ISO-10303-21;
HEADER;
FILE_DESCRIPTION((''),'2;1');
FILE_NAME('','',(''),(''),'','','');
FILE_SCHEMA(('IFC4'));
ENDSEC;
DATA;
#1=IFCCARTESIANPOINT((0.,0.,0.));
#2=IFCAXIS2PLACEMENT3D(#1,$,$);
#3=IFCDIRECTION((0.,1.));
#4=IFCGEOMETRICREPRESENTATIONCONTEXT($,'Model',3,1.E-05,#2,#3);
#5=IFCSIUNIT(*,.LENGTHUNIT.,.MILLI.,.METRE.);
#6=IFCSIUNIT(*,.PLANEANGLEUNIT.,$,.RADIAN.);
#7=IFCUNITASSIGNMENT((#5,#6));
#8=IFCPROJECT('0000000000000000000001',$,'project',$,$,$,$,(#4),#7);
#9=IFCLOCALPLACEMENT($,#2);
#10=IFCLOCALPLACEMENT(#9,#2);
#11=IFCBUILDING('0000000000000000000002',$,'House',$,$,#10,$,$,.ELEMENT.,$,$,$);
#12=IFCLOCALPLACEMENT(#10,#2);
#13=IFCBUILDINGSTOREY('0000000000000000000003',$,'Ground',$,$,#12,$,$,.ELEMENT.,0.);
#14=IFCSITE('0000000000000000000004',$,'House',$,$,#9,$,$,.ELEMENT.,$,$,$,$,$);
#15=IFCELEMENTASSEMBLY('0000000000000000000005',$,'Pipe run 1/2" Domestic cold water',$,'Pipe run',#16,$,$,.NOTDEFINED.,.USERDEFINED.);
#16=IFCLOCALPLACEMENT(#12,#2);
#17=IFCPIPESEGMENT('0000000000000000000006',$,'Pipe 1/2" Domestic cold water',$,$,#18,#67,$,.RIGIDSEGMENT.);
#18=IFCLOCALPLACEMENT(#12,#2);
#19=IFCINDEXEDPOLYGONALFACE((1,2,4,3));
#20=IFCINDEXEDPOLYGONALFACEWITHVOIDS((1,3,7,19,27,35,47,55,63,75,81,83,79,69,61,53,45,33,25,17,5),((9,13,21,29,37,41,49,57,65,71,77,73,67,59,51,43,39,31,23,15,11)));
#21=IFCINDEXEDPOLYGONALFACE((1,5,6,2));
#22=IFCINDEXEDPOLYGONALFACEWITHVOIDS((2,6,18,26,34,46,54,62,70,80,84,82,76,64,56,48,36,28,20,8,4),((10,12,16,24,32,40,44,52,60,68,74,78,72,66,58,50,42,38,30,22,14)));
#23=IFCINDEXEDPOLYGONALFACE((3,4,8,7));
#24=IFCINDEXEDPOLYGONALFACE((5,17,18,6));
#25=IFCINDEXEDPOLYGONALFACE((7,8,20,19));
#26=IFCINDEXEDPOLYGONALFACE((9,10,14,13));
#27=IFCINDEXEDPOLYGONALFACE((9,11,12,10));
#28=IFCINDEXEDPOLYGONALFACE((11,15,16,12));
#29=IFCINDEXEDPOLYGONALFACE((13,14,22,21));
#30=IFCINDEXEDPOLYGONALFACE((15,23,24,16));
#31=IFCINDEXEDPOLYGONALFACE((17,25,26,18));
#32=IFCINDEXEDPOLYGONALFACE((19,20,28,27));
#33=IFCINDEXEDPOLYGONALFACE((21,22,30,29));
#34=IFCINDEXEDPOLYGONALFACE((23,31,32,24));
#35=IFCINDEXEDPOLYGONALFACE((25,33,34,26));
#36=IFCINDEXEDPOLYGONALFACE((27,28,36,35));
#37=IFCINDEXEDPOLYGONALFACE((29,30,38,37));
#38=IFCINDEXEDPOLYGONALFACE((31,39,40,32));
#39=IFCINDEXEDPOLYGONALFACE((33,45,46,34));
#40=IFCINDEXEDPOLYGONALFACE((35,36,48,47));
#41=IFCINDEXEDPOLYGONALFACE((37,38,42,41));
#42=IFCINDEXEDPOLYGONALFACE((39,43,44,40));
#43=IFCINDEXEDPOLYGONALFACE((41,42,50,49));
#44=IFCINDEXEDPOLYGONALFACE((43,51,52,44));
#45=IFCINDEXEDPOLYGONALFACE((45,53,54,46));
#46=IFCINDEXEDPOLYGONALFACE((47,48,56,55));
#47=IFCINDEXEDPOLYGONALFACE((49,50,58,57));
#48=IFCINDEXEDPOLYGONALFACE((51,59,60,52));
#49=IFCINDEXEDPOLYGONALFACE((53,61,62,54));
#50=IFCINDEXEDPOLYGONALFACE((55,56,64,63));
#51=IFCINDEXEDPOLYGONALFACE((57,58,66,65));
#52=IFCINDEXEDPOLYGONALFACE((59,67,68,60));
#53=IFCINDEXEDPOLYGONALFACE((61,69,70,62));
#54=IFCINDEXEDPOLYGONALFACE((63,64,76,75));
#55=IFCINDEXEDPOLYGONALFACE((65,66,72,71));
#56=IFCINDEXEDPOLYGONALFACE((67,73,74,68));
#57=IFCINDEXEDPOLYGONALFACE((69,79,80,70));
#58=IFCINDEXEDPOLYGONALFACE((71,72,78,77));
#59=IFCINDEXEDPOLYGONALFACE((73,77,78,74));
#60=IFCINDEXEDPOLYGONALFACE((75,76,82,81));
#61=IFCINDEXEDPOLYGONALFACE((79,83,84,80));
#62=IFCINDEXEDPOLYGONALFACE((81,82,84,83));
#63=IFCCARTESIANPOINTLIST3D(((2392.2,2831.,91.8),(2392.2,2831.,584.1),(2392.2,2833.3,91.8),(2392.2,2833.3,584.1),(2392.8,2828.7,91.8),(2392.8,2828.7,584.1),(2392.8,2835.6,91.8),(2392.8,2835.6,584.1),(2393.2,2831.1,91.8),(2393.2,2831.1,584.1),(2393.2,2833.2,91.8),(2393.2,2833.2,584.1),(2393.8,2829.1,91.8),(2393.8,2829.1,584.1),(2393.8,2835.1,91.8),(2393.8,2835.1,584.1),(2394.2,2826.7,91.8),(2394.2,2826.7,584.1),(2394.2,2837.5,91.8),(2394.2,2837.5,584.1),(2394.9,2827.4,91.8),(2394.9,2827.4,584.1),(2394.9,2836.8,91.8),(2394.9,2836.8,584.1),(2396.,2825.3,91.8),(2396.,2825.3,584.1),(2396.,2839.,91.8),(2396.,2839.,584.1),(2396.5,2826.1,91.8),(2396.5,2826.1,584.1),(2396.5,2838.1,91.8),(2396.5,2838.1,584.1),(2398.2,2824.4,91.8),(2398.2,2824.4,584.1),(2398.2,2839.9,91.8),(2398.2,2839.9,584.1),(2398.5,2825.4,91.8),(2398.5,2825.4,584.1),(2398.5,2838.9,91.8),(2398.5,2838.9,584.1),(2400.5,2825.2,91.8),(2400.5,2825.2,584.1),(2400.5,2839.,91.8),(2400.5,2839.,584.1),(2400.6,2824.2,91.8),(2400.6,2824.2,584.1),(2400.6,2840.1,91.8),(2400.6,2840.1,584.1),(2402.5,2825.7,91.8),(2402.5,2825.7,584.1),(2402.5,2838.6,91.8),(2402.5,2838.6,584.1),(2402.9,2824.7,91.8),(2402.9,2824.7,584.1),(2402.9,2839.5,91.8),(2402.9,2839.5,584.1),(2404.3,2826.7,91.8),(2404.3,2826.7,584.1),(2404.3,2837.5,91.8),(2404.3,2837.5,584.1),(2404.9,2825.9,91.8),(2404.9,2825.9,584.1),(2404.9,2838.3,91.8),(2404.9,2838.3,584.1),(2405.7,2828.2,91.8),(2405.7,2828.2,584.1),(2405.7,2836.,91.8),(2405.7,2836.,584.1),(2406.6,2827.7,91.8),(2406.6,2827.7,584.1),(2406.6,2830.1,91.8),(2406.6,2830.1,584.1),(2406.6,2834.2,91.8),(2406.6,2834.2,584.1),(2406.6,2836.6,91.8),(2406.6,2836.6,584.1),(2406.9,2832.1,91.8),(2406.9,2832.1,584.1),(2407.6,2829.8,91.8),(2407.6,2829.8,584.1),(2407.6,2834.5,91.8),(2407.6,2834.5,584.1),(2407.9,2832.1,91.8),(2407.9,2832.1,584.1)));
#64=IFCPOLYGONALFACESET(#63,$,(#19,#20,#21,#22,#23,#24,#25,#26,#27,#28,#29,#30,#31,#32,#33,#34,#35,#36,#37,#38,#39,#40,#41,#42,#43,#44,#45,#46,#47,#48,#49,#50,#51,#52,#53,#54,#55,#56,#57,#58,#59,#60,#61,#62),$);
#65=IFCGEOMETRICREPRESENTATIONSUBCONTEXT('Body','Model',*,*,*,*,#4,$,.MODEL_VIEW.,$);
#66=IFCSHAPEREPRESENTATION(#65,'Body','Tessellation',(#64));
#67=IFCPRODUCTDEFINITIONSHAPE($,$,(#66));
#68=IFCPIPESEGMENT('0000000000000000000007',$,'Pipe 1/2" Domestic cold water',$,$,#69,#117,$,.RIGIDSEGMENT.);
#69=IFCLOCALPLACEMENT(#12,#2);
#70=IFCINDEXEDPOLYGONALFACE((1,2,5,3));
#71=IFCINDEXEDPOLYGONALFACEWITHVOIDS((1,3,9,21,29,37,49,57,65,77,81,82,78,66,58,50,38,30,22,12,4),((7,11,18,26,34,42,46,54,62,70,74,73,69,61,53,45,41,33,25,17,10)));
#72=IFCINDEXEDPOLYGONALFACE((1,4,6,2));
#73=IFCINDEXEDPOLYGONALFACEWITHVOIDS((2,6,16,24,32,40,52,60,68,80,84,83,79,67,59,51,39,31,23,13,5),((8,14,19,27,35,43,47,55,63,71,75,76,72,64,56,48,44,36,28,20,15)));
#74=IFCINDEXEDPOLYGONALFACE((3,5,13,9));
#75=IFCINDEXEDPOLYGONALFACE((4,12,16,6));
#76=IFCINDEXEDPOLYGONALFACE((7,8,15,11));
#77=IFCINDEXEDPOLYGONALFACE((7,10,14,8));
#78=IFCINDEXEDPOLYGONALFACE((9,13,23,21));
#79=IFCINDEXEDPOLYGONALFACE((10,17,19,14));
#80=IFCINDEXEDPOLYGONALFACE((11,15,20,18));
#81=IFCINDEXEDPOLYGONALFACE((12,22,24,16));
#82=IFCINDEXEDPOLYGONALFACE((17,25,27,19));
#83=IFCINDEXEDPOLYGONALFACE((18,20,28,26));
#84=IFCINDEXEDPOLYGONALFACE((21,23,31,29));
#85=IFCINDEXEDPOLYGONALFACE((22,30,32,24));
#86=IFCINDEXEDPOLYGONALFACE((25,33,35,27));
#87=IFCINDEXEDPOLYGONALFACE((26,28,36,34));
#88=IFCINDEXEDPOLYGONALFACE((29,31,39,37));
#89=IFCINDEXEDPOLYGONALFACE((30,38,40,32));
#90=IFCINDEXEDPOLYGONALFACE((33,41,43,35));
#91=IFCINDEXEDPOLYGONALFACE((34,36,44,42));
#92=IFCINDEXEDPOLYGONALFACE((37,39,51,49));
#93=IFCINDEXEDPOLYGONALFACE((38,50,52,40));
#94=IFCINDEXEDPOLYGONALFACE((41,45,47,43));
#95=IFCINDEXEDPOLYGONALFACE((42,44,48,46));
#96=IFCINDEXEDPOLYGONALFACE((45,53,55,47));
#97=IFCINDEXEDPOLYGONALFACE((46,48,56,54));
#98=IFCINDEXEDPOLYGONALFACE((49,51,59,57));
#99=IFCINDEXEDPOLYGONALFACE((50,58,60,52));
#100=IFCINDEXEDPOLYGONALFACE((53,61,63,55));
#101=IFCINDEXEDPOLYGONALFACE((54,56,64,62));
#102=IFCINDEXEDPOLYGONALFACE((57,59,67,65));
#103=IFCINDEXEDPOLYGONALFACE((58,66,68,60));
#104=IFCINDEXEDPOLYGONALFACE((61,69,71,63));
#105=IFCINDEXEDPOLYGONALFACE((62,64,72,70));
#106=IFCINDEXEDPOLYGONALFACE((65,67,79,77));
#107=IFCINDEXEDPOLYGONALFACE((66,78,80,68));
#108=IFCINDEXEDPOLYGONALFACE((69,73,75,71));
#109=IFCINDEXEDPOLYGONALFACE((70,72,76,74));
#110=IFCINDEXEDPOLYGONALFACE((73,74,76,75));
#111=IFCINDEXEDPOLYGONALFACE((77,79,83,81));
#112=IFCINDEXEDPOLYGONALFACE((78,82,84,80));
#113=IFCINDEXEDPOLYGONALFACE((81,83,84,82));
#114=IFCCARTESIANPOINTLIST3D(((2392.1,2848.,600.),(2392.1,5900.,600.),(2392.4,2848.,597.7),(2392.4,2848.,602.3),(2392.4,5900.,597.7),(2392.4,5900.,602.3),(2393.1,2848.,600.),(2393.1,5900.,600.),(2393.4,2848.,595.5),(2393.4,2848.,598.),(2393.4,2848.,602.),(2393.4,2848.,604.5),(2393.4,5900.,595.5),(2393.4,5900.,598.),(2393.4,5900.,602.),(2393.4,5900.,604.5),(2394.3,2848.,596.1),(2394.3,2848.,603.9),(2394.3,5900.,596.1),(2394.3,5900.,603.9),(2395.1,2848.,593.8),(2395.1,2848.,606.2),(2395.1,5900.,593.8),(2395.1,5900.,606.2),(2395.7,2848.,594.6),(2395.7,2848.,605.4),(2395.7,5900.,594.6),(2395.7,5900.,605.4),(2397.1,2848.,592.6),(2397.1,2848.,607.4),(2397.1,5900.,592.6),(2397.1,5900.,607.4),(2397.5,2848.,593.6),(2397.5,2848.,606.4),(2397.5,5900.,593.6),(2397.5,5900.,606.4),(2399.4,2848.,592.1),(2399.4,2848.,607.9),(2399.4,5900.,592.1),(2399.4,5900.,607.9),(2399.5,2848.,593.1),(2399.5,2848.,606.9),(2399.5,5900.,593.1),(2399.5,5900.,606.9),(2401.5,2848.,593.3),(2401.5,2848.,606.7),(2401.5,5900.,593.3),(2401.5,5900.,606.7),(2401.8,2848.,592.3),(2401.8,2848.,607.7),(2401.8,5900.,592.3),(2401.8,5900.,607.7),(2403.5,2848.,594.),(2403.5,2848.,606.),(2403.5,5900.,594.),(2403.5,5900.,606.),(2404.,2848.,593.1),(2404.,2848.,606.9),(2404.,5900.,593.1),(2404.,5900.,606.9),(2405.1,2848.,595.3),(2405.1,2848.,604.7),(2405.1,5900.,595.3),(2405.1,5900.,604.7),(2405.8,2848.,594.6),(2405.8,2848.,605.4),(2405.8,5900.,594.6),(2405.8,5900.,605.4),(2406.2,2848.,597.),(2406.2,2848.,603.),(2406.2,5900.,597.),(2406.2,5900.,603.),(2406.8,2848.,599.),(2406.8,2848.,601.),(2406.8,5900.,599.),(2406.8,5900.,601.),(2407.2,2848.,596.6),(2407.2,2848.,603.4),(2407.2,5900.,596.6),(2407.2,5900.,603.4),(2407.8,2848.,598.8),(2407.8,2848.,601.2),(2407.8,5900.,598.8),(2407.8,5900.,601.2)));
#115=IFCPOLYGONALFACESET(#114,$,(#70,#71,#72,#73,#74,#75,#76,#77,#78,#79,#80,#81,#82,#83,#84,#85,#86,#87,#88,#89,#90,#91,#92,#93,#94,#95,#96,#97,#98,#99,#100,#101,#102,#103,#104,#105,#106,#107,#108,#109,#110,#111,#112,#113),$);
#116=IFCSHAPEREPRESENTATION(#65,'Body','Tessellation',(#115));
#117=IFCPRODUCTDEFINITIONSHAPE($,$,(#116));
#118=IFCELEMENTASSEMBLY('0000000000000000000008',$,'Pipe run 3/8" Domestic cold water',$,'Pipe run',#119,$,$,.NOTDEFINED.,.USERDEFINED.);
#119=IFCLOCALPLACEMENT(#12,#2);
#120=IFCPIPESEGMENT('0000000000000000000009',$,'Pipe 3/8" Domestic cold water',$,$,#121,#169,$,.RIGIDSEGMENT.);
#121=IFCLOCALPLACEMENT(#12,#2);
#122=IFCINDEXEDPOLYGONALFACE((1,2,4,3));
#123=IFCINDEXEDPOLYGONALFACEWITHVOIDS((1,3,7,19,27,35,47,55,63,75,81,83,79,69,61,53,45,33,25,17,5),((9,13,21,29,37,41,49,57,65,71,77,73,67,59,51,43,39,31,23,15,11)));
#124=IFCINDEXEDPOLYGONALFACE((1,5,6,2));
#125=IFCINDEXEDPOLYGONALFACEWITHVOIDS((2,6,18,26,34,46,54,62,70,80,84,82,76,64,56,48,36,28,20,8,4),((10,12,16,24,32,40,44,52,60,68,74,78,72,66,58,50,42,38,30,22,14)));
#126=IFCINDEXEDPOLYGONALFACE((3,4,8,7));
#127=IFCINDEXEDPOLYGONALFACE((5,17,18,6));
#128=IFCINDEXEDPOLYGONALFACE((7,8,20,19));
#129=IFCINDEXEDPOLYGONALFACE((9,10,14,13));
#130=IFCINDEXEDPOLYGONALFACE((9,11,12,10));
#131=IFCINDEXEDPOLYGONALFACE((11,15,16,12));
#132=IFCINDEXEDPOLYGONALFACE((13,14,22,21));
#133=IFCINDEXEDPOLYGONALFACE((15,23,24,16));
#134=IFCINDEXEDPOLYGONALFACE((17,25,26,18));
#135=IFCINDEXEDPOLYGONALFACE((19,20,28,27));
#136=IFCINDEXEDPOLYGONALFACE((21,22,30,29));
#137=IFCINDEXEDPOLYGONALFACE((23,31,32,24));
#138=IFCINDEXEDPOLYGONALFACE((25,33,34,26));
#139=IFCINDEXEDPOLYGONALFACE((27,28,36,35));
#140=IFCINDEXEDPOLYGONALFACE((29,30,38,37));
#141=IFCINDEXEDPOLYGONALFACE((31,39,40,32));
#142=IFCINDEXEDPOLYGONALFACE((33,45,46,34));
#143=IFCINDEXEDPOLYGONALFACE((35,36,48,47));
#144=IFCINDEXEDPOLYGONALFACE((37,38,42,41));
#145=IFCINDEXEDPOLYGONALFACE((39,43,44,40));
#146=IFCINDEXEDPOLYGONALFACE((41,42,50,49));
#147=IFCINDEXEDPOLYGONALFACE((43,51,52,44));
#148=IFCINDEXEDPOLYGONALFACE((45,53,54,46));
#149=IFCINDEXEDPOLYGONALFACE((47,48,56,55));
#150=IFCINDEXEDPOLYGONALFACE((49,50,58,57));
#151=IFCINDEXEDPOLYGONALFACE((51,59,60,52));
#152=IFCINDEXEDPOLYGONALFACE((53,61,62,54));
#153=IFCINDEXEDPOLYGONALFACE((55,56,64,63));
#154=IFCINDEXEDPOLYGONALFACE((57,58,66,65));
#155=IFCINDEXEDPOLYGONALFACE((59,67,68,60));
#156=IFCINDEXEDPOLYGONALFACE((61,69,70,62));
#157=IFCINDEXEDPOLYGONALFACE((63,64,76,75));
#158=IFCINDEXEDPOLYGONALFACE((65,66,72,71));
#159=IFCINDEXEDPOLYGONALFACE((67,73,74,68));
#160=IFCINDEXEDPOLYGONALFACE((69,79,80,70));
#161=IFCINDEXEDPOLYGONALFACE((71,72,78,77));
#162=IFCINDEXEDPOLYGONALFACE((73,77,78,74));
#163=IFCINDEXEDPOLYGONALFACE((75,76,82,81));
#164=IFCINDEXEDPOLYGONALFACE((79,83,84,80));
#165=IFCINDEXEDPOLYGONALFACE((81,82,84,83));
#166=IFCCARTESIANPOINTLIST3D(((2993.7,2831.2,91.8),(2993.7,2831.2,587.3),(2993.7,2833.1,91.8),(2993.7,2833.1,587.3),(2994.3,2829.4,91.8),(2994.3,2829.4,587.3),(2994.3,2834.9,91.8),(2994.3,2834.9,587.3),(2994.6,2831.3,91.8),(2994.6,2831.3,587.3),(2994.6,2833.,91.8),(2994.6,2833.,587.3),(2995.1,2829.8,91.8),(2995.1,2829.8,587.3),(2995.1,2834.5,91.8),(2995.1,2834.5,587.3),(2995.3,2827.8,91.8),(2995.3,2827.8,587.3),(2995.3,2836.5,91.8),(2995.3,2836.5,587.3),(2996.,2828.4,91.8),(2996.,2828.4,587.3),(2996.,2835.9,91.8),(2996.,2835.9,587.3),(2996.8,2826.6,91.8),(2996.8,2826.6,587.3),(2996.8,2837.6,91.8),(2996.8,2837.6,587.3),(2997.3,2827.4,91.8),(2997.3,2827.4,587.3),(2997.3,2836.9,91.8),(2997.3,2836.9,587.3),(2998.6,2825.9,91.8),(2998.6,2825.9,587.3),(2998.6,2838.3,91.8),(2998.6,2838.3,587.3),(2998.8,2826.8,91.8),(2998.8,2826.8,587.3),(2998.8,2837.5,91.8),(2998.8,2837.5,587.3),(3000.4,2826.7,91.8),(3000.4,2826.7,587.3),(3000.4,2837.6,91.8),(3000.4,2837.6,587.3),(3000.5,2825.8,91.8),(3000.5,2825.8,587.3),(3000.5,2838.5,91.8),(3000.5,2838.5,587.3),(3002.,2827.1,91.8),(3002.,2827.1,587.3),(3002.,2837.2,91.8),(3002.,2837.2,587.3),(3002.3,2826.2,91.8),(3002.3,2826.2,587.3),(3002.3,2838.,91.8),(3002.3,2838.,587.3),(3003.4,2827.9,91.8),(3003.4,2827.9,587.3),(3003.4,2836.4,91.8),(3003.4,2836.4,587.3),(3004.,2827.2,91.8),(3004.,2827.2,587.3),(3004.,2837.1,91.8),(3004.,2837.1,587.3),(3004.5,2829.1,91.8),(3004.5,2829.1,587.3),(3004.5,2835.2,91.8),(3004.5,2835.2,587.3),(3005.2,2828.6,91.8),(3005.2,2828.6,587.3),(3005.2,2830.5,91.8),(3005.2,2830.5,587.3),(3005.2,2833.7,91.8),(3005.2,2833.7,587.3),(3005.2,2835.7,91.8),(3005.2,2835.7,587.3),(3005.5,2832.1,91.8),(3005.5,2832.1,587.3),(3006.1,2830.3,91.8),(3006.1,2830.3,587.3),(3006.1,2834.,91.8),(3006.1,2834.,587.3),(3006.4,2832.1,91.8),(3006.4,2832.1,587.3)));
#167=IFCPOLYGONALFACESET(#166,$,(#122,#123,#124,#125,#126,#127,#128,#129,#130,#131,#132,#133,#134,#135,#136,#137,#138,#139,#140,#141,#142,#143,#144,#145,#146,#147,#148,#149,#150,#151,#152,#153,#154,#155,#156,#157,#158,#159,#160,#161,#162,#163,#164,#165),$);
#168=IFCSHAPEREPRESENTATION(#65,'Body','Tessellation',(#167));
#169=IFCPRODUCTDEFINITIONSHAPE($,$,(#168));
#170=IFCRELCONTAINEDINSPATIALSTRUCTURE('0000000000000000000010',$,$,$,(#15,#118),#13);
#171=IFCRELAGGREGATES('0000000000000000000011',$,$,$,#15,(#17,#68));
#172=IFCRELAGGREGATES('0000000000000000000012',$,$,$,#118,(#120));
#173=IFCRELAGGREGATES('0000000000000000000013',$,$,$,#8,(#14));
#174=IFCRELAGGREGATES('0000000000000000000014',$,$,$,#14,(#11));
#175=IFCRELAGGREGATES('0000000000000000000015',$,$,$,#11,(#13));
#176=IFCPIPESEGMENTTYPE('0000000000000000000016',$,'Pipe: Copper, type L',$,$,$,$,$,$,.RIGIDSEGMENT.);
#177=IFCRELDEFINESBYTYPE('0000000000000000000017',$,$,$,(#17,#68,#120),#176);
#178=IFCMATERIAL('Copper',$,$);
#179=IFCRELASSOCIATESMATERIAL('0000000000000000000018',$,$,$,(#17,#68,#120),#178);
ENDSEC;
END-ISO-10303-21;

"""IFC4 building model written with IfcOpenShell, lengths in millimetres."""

from ifc_helpers import new_model, si_unit, direction, frame, origin, origin_with_axes, origin_2d, place, context, subcontext, project, spatial, hollow_circle, extrude, material, type_object, element, aggregate, save


model = new_model("IFC4")

# Units and contexts
model_context = context("Model", 3, precision=1e-05, world=origin(), true_north=direction((0.0, 1.0)))
body_context = subcontext(model_context, "Body", "Model", "MODEL_VIEW")
ifc_project = project(units=[si_unit("LENGTHUNIT", "METRE", prefix="MILLI"), si_unit("PLANEANGLEUNIT", "RADIAN")], contexts=[model_context])

# Site, building, storey
site_placement = place(None, origin())
site = spatial("IfcSite", under=ifc_project, at=site_placement, Name="House", CompositionType="ELEMENT")
building_placement = place(site_placement, origin())
building = spatial("IfcBuilding", under=site, at=building_placement, Name="House", CompositionType="ELEMENT")
storey_placement = place(building_placement, origin())
storey = spatial("IfcBuildingStorey", under=building, at=storey_placement, Name="Ground", CompositionType="ELEMENT", Elevation=0.0)

# Shared definitions
ifc_material = material(Name="Copper")
pipe_segment_type = type_object("IfcPipeSegmentType", Name="Pipe: Copper, type L", PredefinedType="RIGIDSEGMENT")

# Element assemblies, pipe segments
assembly_1_placement = place(storey_placement, origin_with_axes())
assembly_1 = element("IfcElementAssembly", 1, at=assembly_1_placement, inside=storey, Name="Pipe run 1/2\" Domestic cold water", ObjectType="Pipe run", AssemblyPlace="NOTDEFINED", PredefinedType="USERDEFINED")
pipe_segment_1_placement = place(storey_placement, origin_with_axes())
pipe_segment_1 = element("IfcPipeSegment", 2, at=pipe_segment_1_placement, type_object=pipe_segment_type, material=ifc_material, Name="Pipe 1/2\" Domestic cold water", PredefinedType="RIGIDSEGMENT", context=body_context, shape_type="SweptSolid", body=[
    extrude(hollow_circle(Radius=7.9, WallThickness=1.0, at=origin_2d()), frame((2400.0, 2832.1, 91.8), z_axis=(0.0, 0.0, 1.0), x_axis=(1.0, 0.0, 0.0)), (0.0, 0.0, 1.0), 492.3),
])
pipe_segment_2_placement = place(storey_placement, origin_with_axes())
pipe_segment_2 = element("IfcPipeSegment", 3, at=pipe_segment_2_placement, type_object=pipe_segment_type, material=ifc_material, Name="Pipe 1/2\" Domestic cold water", PredefinedType="RIGIDSEGMENT", context=body_context, shape_type="SweptSolid", body=[
    extrude(hollow_circle(Radius=7.9, WallThickness=1.0, at=origin_2d()), frame((2400.0, 2848.0, 600.0), z_axis=(0.0, 1.0, 0.0), x_axis=(-1.0, 0.0, 0.0)), (0.0, 0.0, 1.0), 3052.0),
])
assembly_2_placement = place(storey_placement, origin_with_axes())
assembly_2 = element("IfcElementAssembly", 4, at=assembly_2_placement, inside=storey, Name="Pipe run 3/8\" Domestic cold water", ObjectType="Pipe run", AssemblyPlace="NOTDEFINED", PredefinedType="USERDEFINED")
pipe_segment_3_placement = place(storey_placement, origin_with_axes())
pipe_segment_3 = element("IfcPipeSegment", 5, at=pipe_segment_3_placement, type_object=pipe_segment_type, material=ifc_material, Name="Pipe 3/8\" Domestic cold water", PredefinedType="RIGIDSEGMENT", context=body_context, shape_type="SweptSolid", body=[
    extrude(hollow_circle(Radius=6.3, WallThickness=0.9, at=origin_2d()), frame((3000.0, 2832.1, 91.8), z_axis=(0.0, 0.0, 1.0), x_axis=(1.0, 0.0, 0.0)), (0.0, 0.0, 1.0), 495.5),
])

aggregate(assembly_1, [pipe_segment_1, pipe_segment_2])
aggregate(assembly_2, [pipe_segment_3])

save(model, "model.ifc")
